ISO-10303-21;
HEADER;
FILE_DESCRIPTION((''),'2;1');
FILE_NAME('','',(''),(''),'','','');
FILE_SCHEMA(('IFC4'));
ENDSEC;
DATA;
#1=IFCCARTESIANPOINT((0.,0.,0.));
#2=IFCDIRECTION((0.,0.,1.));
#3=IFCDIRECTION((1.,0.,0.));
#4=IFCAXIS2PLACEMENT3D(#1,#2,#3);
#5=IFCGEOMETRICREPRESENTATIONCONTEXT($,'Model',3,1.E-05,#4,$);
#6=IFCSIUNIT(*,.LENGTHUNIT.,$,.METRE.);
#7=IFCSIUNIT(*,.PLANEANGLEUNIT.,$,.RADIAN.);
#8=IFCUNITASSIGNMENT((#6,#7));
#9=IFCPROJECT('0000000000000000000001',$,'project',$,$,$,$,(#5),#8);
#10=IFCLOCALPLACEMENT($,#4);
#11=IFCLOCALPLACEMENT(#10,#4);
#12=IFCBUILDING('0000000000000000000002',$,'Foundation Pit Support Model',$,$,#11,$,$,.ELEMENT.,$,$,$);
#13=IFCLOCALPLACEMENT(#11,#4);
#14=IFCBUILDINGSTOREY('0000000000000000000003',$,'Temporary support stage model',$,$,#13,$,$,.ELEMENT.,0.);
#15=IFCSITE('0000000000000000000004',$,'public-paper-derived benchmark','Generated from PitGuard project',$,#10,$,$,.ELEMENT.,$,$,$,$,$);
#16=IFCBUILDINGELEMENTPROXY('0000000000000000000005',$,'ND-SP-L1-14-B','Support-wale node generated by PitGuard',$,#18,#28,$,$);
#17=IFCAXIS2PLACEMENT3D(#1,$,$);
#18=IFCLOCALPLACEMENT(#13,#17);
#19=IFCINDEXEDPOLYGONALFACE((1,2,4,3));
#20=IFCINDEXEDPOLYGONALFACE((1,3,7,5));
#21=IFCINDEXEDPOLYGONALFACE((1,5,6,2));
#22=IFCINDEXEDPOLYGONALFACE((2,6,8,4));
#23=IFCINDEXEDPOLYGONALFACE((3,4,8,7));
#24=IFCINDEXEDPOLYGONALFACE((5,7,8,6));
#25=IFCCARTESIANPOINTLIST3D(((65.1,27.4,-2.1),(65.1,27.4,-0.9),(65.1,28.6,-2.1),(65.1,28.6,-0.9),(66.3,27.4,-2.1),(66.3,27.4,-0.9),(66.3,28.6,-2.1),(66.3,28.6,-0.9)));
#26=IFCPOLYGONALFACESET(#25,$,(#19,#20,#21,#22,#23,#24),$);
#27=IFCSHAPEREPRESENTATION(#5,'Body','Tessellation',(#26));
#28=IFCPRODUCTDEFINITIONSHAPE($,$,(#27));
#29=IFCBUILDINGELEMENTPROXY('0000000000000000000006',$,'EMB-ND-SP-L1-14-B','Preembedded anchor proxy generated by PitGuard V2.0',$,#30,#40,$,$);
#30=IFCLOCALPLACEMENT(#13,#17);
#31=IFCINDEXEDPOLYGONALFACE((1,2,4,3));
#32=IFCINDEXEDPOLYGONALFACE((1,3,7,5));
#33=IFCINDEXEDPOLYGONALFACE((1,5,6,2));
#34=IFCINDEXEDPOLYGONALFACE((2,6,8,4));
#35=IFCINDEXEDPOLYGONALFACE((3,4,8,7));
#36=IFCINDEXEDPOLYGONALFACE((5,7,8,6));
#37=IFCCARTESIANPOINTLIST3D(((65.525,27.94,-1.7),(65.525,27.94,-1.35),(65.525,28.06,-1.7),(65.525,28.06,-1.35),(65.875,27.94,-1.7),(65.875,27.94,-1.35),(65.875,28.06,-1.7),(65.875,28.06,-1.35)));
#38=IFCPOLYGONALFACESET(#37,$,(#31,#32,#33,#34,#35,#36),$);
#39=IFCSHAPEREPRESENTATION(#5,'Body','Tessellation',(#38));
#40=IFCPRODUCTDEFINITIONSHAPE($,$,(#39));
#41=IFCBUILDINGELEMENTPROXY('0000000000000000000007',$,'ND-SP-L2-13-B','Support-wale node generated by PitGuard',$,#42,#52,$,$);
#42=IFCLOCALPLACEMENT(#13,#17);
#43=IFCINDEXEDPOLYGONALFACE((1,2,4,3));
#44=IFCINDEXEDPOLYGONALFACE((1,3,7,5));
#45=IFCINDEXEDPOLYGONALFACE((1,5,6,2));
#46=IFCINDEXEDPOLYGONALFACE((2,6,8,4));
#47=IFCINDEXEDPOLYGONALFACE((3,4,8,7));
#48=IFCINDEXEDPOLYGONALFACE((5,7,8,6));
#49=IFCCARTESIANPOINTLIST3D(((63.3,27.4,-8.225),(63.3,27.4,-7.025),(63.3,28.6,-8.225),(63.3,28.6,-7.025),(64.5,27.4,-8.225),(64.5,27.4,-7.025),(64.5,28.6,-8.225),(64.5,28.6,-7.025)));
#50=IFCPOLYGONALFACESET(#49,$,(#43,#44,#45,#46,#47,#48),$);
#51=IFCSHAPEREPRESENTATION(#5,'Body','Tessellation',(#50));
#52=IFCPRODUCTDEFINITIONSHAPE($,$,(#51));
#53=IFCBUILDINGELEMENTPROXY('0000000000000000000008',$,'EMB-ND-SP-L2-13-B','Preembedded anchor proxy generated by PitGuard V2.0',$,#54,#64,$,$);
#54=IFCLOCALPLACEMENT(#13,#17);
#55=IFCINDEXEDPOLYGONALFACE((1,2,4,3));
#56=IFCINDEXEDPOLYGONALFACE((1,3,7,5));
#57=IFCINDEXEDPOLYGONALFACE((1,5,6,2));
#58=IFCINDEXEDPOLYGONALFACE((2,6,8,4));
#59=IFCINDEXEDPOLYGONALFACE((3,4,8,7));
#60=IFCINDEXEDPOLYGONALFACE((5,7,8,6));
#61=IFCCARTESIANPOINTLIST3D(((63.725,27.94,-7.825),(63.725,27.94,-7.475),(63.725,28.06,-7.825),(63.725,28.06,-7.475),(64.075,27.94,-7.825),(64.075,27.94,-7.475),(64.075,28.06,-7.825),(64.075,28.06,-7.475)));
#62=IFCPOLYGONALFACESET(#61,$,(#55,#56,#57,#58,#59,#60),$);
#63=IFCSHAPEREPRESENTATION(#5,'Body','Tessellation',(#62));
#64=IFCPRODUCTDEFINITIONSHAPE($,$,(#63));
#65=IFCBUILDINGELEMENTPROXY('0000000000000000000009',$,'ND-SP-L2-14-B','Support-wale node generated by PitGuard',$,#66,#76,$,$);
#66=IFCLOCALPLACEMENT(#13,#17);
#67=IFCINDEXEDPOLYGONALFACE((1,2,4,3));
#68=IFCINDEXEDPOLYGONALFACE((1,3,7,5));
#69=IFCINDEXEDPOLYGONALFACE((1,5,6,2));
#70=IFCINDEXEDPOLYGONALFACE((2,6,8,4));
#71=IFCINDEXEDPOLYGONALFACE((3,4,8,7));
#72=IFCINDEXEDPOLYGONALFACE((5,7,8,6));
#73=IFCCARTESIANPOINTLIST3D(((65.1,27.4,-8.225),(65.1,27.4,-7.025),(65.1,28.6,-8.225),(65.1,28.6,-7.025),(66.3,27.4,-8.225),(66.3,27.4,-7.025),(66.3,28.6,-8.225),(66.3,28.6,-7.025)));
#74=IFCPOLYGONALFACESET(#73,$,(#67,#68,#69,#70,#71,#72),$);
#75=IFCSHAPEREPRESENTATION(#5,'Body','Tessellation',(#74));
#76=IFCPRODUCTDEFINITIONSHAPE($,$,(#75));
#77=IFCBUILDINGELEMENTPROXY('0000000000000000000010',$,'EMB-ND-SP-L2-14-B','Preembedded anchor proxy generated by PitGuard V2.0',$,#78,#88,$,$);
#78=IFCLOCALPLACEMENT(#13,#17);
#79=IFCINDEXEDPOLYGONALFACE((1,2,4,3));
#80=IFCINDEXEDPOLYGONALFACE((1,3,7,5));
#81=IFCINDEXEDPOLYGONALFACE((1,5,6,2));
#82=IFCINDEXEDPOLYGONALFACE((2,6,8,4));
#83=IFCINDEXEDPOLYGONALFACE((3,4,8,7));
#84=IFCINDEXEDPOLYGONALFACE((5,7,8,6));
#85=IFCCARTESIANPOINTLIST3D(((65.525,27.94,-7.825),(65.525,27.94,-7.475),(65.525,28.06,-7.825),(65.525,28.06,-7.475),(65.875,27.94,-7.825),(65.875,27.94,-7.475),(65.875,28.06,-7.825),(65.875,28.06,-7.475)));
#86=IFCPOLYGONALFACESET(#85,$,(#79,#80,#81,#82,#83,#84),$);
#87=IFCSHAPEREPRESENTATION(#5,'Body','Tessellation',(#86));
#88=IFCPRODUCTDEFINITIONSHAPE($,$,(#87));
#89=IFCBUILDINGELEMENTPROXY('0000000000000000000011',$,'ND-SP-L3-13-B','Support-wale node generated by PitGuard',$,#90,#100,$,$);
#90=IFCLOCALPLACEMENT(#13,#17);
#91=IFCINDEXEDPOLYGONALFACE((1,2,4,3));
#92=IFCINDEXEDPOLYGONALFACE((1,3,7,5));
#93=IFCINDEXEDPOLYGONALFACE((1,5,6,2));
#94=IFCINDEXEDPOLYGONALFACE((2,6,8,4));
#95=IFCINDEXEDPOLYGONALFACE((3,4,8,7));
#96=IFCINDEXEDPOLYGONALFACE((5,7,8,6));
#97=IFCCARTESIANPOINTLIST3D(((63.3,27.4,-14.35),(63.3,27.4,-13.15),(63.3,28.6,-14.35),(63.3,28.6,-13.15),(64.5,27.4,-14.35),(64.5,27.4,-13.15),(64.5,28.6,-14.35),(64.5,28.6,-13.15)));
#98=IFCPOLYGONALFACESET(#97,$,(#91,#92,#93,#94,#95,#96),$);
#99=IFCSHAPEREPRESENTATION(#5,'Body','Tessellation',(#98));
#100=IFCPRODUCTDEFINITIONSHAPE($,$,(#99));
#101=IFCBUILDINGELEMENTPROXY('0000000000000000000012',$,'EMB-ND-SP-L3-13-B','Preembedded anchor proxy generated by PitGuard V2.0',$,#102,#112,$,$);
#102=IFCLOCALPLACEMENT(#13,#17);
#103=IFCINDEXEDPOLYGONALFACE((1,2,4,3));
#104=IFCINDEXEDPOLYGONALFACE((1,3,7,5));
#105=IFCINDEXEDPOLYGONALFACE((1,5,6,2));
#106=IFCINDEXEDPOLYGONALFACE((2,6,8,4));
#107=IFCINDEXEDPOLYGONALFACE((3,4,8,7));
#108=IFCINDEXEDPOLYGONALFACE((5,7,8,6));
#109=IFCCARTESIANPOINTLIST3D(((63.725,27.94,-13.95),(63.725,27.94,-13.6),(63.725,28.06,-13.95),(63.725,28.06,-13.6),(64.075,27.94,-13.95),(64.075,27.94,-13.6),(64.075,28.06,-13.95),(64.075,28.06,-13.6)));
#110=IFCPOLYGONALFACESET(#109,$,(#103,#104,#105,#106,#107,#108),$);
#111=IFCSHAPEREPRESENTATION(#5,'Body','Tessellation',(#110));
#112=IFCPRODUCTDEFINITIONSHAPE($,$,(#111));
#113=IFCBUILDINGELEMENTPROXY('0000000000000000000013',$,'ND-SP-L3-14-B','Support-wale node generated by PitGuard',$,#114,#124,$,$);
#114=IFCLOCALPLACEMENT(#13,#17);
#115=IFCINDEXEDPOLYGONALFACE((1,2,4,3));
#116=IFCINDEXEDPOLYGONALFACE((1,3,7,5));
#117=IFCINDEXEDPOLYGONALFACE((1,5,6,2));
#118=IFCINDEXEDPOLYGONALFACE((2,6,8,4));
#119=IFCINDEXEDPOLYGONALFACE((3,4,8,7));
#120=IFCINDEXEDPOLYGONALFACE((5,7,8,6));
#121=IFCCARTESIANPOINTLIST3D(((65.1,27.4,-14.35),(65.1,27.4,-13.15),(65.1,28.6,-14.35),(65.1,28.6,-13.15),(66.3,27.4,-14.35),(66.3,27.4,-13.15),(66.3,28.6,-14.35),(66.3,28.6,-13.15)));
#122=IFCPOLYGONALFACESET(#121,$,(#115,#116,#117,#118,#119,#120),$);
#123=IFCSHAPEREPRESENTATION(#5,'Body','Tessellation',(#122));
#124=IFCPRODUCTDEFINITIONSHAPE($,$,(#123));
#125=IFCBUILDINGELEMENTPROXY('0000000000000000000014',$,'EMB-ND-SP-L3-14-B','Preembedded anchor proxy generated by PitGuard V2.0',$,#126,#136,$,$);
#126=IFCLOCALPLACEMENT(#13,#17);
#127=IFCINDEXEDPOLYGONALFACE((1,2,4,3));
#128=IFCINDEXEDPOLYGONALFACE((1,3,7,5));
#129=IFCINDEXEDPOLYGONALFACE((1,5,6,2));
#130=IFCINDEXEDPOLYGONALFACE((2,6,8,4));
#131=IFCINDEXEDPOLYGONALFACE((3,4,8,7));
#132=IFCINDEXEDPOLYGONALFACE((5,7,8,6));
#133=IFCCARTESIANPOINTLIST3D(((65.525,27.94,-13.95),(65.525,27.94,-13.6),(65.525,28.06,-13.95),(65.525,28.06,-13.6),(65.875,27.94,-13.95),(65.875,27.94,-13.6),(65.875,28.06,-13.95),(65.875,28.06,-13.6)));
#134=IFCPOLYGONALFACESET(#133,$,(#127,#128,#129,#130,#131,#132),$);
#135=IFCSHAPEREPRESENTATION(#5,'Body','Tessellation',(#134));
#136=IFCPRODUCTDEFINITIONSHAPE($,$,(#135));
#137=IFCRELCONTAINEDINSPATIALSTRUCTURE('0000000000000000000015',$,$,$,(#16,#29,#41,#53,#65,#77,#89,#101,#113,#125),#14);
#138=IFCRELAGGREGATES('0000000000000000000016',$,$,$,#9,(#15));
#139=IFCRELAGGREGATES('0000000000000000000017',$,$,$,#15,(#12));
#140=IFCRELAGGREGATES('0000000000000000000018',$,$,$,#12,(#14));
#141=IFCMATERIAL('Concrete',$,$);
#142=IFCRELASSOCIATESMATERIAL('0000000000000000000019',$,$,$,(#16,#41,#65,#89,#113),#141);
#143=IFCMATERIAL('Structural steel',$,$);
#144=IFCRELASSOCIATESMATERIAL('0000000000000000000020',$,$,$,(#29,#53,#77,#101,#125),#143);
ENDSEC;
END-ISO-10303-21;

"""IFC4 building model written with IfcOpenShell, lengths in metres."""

from ifc_helpers import new_model, si_unit, frame, origin_with_axes, origin_2d, place, context, project, spatial, rectangle, extrude, material, element, save


model = new_model("IFC4")

# Units and contexts
model_context = context("Model", 3, precision=1e-05, world=origin_with_axes())
ifc_project = project(units=[si_unit("LENGTHUNIT", "METRE"), si_unit("PLANEANGLEUNIT", "RADIAN")], contexts=[model_context])

# Site, building, storey
site_placement = place(None, origin_with_axes())
site = spatial("IfcSite", under=ifc_project, at=site_placement, Name="public-paper-derived benchmark", Description="Generated from PitGuard project", CompositionType="ELEMENT")
building_placement = place(site_placement, origin_with_axes())
building = spatial("IfcBuilding", under=site, at=building_placement, Name="Foundation Pit Support Model", CompositionType="ELEMENT")
storey_placement = place(building_placement, origin_with_axes())
storey = spatial("IfcBuildingStorey", under=building, at=storey_placement, Name="Temporary support stage model", CompositionType="ELEMENT", Elevation=0.0)

# Shared definitions
ifc_material_1 = material(Name="Concrete")

# Shared definitions
ifc_material_2 = material(Name="Structural steel")

# Building element proxies
proxy_1_placement = place(storey_placement, frame((65.7, 28.0, -2.1), z_axis=(0.0, 0.0, 1.0), x_axis=(1.0, 0.0, 0.0)))
element("IfcBuildingElementProxy", 1, at=proxy_1_placement, inside=storey, material=ifc_material_1, Name="ND-SP-L1-14-B", Description="Support-wale node generated by PitGuard", context=model_context, shape_type="SweptSolid", body=[
    extrude(rectangle(XDim=1.2, YDim=1.2, at=origin_2d()), origin_with_axes(), (0.0, 0.0, 1.0), 1.2),
])
proxy_2_placement = place(storey_placement, frame((65.7, 28.0, -1.7), z_axis=(0.0, 0.0, 1.0), x_axis=(1.0, 0.0, 0.0)))
element("IfcBuildingElementProxy", 2, at=proxy_2_placement, inside=storey, material=ifc_material_2, Name="EMB-ND-SP-L1-14-B", Description="Preembedded anchor proxy generated by PitGuard V2.0", context=model_context, shape_type="SweptSolid", body=[
    extrude(rectangle(XDim=0.35, YDim=0.12, at=origin_2d()), origin_with_axes(), (0.0, 0.0, 1.0), 0.35),
])
proxy_3_placement = place(storey_placement, frame((63.9, 28.0, -8.225), z_axis=(0.0, 0.0, 1.0), x_axis=(1.0, 0.0, 0.0)))
element("IfcBuildingElementProxy", 3, at=proxy_3_placement, inside=storey, material=ifc_material_1, Name="ND-SP-L2-13-B", Description="Support-wale node generated by PitGuard", context=model_context, shape_type="SweptSolid", body=[
    extrude(rectangle(XDim=1.2, YDim=1.2, at=origin_2d()), origin_with_axes(), (0.0, 0.0, 1.0), 1.2),
])
proxy_4_placement = place(storey_placement, frame((63.9, 28.0, -7.825), z_axis=(0.0, 0.0, 1.0), x_axis=(1.0, 0.0, 0.0)))
element("IfcBuildingElementProxy", 4, at=proxy_4_placement, inside=storey, material=ifc_material_2, Name="EMB-ND-SP-L2-13-B", Description="Preembedded anchor proxy generated by PitGuard V2.0", context=model_context, shape_type="SweptSolid", body=[
    extrude(rectangle(XDim=0.35, YDim=0.12, at=origin_2d()), origin_with_axes(), (0.0, 0.0, 1.0), 0.35),
])
proxy_5_placement = place(storey_placement, frame((65.7, 28.0, -8.225), z_axis=(0.0, 0.0, 1.0), x_axis=(1.0, 0.0, 0.0)))
element("IfcBuildingElementProxy", 5, at=proxy_5_placement, inside=storey, material=ifc_material_1, Name="ND-SP-L2-14-B", Description="Support-wale node generated by PitGuard", context=model_context, shape_type="SweptSolid", body=[
    extrude(rectangle(XDim=1.2, YDim=1.2, at=origin_2d()), origin_with_axes(), (0.0, 0.0, 1.0), 1.2),
])
proxy_6_placement = place(storey_placement, frame((65.7, 28.0, -7.825), z_axis=(0.0, 0.0, 1.0), x_axis=(1.0, 0.0, 0.0)))
element("IfcBuildingElementProxy", 6, at=proxy_6_placement, inside=storey, material=ifc_material_2, Name="EMB-ND-SP-L2-14-B", Description="Preembedded anchor proxy generated by PitGuard V2.0", context=model_context, shape_type="SweptSolid", body=[
    extrude(rectangle(XDim=0.35, YDim=0.12, at=origin_2d()), origin_with_axes(), (0.0, 0.0, 1.0), 0.35),
])
proxy_7_placement = place(storey_placement, frame((63.9, 28.0, -14.35), z_axis=(0.0, 0.0, 1.0), x_axis=(1.0, 0.0, 0.0)))
element("IfcBuildingElementProxy", 7, at=proxy_7_placement, inside=storey, material=ifc_material_1, Name="ND-SP-L3-13-B", Description="Support-wale node generated by PitGuard", context=model_context, shape_type="SweptSolid", body=[
    extrude(rectangle(XDim=1.2, YDim=1.2, at=origin_2d()), origin_with_axes(), (0.0, 0.0, 1.0), 1.2),
])
proxy_8_placement = place(storey_placement, frame((63.9, 28.0, -13.95), z_axis=(0.0, 0.0, 1.0), x_axis=(1.0, 0.0, 0.0)))
element("IfcBuildingElementProxy", 8, at=proxy_8_placement, inside=storey, material=ifc_material_2, Name="EMB-ND-SP-L3-13-B", Description="Preembedded anchor proxy generated by PitGuard V2.0", context=model_context, shape_type="SweptSolid", body=[
    extrude(rectangle(XDim=0.35, YDim=0.12, at=origin_2d()), origin_with_axes(), (0.0, 0.0, 1.0), 0.35),
])
proxy_9_placement = place(storey_placement, frame((65.7, 28.0, -14.35), z_axis=(0.0, 0.0, 1.0), x_axis=(1.0, 0.0, 0.0)))
element("IfcBuildingElementProxy", 9, at=proxy_9_placement, inside=storey, material=ifc_material_1, Name="ND-SP-L3-14-B", Description="Support-wale node generated by PitGuard", context=model_context, shape_type="SweptSolid", body=[
    extrude(rectangle(XDim=1.2, YDim=1.2, at=origin_2d()), origin_with_axes(), (0.0, 0.0, 1.0), 1.2),
])
proxy_10_placement = place(storey_placement, frame((65.7, 28.0, -13.95), z_axis=(0.0, 0.0, 1.0), x_axis=(1.0, 0.0, 0.0)))
element("IfcBuildingElementProxy", 10, at=proxy_10_placement, inside=storey, material=ifc_material_2, Name="EMB-ND-SP-L3-14-B", Description="Preembedded anchor proxy generated by PitGuard V2.0", context=model_context, shape_type="SweptSolid", body=[
    extrude(rectangle(XDim=0.35, YDim=0.12, at=origin_2d()), origin_with_axes(), (0.0, 0.0, 1.0), 0.35),
])

save(model, "model.ifc")
